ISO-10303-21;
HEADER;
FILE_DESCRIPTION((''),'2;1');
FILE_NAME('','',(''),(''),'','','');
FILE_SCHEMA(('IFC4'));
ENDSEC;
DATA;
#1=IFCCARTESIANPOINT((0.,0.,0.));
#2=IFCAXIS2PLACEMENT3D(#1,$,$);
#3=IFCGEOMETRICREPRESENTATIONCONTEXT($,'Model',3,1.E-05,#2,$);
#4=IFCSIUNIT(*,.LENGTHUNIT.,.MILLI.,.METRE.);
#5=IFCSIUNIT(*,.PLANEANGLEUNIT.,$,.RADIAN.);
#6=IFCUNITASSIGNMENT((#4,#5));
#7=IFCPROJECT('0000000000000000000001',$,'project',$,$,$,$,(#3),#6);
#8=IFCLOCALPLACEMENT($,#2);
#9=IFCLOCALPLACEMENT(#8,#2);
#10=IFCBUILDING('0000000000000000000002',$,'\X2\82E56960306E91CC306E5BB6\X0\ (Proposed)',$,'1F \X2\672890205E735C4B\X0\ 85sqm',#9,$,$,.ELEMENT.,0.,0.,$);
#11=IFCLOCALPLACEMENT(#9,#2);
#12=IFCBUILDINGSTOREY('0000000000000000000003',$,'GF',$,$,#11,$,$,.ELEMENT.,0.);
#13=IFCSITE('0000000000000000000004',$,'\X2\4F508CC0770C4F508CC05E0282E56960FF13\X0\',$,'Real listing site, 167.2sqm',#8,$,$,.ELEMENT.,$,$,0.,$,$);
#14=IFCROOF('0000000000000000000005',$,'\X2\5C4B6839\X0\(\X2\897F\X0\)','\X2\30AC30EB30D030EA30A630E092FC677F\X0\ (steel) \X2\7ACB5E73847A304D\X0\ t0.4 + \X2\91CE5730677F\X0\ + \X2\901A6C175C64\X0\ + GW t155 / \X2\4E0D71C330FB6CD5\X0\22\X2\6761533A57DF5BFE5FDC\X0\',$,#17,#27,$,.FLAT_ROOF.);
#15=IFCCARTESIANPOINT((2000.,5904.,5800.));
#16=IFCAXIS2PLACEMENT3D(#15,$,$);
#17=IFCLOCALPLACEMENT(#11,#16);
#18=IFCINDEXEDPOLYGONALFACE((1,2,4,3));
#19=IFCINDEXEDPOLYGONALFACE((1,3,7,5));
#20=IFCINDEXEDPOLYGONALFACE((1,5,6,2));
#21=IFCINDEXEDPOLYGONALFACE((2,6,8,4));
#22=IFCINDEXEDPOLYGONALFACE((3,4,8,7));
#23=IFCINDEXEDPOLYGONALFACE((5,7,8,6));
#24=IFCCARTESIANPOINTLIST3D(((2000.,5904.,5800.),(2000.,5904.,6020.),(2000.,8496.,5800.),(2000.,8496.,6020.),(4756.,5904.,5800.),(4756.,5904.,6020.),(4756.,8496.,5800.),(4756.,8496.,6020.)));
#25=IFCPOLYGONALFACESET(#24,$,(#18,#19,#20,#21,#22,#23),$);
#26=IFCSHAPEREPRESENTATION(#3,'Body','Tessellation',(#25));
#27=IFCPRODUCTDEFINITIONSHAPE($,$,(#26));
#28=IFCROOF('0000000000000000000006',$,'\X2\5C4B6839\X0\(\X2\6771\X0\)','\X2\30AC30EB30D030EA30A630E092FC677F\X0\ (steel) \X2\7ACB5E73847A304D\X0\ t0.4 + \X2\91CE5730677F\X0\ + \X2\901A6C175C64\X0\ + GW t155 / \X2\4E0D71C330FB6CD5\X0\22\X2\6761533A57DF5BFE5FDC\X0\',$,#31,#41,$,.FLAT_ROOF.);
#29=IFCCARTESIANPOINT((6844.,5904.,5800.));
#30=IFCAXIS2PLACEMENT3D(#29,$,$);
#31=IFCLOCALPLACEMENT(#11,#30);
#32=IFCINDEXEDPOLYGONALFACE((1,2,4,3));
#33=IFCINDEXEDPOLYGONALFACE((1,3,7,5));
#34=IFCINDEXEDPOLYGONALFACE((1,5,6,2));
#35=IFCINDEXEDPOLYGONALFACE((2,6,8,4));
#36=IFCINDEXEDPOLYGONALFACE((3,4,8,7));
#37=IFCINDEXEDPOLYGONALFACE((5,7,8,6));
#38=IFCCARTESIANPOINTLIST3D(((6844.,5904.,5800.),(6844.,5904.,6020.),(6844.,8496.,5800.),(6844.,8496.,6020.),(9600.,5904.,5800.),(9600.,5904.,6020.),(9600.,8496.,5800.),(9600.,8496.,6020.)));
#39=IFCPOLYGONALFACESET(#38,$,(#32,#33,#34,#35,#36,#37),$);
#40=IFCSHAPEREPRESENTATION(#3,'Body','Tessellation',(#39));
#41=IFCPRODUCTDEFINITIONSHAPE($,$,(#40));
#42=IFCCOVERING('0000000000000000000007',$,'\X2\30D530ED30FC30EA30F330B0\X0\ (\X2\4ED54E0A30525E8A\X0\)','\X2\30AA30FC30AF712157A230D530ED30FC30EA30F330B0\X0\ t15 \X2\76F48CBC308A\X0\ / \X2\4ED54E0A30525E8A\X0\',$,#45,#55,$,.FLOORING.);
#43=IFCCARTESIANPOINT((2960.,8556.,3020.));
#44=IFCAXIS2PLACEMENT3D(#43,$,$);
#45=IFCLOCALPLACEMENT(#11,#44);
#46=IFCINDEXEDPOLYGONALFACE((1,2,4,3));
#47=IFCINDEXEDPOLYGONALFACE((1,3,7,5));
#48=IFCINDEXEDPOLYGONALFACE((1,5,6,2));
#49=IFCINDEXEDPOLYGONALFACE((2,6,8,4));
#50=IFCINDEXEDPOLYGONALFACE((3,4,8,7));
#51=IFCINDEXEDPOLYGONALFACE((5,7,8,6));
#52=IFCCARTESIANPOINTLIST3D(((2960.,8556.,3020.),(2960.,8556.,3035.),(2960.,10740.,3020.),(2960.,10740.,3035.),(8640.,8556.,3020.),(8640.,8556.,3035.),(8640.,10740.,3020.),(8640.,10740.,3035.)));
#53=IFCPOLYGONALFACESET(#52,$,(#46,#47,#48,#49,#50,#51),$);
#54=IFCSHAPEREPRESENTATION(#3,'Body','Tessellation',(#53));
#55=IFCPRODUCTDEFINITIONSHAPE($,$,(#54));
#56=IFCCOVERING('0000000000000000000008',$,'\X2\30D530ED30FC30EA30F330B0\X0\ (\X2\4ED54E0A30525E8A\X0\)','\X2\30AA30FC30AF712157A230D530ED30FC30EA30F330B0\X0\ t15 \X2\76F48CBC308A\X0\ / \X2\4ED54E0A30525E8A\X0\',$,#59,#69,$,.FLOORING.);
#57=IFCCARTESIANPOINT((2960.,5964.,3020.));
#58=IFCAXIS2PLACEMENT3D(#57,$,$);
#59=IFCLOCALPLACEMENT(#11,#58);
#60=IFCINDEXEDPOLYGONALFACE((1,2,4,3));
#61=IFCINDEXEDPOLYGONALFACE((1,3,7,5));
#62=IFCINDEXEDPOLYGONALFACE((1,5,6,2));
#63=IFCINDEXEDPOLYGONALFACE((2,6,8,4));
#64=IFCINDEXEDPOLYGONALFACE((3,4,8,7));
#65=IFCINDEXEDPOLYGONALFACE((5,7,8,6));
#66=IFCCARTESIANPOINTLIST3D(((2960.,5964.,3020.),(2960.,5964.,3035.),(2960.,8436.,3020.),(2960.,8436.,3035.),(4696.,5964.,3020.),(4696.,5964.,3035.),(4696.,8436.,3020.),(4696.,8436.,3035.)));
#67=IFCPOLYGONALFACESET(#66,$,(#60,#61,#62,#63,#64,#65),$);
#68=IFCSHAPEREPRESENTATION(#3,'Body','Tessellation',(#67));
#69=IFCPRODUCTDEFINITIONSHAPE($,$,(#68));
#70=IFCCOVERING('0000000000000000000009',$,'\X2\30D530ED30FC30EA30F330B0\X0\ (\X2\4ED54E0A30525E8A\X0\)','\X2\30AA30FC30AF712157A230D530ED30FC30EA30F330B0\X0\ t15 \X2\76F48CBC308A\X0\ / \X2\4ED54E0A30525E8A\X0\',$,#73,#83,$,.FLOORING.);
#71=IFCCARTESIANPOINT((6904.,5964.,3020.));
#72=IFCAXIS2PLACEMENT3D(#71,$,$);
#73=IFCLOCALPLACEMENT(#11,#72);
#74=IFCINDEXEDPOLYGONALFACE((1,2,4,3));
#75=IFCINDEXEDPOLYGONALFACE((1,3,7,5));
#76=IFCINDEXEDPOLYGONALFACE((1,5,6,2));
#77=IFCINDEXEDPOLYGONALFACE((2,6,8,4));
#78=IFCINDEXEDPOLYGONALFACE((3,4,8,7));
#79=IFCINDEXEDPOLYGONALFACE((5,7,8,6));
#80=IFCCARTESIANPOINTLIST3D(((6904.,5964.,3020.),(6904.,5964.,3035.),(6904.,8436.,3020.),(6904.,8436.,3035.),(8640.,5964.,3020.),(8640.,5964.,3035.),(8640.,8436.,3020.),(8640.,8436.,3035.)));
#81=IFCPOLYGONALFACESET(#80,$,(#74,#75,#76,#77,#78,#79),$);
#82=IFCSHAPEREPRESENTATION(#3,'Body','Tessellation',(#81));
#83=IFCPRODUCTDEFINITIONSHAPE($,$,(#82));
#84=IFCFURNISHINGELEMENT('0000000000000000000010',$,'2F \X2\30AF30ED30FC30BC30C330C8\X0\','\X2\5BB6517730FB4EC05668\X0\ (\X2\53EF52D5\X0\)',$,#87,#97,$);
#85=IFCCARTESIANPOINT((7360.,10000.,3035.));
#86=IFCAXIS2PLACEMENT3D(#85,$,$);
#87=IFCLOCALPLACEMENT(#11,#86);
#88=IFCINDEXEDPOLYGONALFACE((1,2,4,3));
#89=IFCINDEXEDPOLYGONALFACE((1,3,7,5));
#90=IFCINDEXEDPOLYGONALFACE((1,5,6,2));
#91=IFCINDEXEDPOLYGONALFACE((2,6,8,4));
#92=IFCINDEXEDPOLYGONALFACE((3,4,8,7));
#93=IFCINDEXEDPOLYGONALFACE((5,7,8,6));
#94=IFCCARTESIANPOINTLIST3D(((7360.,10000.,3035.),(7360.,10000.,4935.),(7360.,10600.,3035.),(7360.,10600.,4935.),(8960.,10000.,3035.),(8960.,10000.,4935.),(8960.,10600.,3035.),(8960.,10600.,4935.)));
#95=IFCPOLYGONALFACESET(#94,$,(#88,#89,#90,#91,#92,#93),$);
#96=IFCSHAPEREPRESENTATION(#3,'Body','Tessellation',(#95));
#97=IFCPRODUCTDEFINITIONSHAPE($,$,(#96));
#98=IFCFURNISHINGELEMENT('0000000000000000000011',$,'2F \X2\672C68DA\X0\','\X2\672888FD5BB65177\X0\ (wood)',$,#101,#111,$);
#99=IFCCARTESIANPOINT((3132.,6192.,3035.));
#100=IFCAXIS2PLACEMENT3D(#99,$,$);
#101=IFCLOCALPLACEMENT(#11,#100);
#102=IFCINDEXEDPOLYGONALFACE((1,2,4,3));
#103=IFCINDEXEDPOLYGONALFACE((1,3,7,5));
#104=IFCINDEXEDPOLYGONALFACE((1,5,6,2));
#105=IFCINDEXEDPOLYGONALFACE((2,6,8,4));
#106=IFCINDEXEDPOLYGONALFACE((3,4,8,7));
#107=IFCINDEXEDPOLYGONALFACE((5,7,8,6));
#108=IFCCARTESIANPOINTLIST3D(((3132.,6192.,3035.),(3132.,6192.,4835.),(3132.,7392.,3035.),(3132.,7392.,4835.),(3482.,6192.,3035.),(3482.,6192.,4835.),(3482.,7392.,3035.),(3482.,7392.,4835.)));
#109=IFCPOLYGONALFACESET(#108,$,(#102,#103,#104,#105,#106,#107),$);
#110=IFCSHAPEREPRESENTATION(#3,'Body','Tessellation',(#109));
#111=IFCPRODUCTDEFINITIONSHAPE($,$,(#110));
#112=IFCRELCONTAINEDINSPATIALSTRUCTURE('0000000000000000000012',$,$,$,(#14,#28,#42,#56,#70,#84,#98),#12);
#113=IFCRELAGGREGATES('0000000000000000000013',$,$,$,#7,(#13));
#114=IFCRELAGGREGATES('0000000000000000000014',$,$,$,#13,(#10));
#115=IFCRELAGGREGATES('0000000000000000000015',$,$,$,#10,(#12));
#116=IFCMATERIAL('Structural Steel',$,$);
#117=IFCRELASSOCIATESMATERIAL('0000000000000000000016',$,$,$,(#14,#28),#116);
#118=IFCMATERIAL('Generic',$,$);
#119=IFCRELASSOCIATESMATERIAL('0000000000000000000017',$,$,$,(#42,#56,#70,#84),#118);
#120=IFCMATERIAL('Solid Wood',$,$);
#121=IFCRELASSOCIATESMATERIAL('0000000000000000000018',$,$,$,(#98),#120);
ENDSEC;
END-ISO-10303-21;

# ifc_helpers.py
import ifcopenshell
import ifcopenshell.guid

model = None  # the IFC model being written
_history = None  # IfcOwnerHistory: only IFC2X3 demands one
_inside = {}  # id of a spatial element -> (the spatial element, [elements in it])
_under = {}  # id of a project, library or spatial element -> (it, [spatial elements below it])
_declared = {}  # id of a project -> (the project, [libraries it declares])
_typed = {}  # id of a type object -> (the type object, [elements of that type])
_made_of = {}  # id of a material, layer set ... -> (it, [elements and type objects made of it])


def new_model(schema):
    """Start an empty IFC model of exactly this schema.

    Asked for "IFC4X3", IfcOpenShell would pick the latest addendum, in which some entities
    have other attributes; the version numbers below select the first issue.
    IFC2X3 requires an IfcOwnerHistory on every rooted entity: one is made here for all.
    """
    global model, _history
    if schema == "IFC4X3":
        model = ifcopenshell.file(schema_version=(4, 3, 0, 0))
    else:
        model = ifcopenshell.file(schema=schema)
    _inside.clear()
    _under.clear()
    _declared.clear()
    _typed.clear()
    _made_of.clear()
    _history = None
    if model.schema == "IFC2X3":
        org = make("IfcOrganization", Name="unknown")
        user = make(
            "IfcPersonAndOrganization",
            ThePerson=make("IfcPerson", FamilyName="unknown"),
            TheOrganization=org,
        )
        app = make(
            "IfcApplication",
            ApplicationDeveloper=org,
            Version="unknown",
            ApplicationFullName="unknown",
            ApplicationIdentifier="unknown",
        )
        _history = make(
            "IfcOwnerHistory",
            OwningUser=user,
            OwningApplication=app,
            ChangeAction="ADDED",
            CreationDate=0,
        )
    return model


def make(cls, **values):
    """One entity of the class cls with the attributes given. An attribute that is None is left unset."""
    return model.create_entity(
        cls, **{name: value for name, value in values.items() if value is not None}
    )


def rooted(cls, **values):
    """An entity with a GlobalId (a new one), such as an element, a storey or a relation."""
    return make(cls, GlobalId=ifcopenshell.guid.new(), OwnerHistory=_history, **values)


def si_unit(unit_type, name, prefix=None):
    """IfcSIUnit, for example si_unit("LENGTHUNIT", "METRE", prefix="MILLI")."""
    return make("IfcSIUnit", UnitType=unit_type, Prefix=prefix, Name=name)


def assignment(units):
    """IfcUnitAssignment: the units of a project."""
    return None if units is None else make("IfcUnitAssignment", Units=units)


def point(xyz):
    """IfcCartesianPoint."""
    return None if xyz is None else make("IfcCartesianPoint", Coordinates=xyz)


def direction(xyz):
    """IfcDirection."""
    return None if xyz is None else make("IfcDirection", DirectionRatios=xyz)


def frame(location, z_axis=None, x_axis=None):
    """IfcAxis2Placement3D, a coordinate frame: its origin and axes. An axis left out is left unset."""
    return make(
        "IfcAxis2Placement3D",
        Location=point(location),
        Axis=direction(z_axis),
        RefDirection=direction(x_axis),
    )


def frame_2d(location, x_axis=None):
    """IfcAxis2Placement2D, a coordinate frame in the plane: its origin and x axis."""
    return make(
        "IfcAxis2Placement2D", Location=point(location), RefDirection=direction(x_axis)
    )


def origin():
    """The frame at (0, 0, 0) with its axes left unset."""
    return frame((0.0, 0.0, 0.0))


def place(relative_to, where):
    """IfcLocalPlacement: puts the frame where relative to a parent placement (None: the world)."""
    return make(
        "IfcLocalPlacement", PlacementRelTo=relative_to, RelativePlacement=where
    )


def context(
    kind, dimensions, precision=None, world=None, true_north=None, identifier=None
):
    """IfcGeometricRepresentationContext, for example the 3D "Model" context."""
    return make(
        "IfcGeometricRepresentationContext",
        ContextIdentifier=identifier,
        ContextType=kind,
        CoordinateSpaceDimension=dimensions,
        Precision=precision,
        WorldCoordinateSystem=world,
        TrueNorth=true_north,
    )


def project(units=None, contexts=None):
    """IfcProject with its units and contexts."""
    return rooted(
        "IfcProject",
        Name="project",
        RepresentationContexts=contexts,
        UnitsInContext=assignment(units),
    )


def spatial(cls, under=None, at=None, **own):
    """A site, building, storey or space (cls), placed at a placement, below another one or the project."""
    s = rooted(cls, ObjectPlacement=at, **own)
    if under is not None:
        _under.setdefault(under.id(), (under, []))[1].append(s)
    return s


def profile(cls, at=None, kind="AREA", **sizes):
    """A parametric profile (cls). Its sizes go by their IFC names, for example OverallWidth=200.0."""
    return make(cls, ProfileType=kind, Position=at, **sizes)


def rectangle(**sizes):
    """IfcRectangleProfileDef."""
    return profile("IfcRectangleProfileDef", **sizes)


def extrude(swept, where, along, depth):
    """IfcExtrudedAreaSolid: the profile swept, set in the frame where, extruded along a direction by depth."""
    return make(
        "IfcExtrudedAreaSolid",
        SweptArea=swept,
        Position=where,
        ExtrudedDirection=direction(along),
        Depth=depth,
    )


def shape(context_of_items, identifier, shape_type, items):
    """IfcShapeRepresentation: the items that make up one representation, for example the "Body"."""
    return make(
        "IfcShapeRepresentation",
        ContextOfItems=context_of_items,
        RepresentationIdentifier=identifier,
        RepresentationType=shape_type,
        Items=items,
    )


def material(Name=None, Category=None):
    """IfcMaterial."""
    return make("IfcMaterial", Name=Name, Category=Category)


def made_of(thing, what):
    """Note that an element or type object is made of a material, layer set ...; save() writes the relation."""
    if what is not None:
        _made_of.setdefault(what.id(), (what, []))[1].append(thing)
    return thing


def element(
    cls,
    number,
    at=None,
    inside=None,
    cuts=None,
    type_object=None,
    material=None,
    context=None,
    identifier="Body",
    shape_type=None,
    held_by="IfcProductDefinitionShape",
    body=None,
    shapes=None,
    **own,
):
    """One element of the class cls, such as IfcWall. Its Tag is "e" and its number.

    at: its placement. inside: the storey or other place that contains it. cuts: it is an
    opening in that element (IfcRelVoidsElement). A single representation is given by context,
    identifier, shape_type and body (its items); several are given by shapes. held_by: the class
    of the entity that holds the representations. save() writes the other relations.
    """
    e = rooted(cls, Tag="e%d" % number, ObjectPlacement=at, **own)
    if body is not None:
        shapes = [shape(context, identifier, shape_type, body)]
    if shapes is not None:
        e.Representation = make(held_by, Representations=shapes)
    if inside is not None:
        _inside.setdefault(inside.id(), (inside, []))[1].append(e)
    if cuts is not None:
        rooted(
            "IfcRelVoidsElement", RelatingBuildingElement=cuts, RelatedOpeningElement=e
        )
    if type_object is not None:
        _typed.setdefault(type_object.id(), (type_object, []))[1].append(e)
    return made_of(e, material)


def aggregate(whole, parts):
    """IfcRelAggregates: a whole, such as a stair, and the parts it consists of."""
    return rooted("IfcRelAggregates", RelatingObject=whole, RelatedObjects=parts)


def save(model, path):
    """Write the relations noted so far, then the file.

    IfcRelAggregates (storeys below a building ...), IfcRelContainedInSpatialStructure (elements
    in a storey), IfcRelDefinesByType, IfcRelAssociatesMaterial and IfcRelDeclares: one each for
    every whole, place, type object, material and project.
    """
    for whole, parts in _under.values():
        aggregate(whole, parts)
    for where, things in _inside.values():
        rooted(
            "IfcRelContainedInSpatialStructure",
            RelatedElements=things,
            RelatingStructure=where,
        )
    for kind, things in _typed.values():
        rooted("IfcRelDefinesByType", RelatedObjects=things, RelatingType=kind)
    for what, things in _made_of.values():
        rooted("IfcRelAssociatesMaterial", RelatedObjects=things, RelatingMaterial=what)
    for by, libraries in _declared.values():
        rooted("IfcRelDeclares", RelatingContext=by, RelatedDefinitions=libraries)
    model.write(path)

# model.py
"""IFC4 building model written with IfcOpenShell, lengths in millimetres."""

from ifc_helpers import new_model, si_unit, frame, frame_2d, origin, place, context, project, spatial, rectangle, extrude, material, element, save


model = new_model("IFC4")

# Units and contexts
model_context = context("Model", 3, precision=1e-05, world=origin())
ifc_project = project(units=[si_unit("LENGTHUNIT", "METRE", prefix="MILLI"), si_unit("PLANEANGLEUNIT", "RADIAN")], contexts=[model_context])

# Site, building, storey
site_placement = place(None, origin())
site = spatial("IfcSite", under=ifc_project, at=site_placement, Name="佐賀県佐賀市若楠３", ObjectType="Real listing site, 167.2sqm", CompositionType="ELEMENT", RefElevation=0.0)
building_placement = place(site_placement, origin())
building = spatial("IfcBuilding", under=site, at=building_placement, Name="若楠の里の家 (Proposed)", ObjectType="1F 木造平屋 85sqm", CompositionType="ELEMENT", ElevationOfRefHeight=0.0, ElevationOfTerrain=0.0)
storey_placement = place(building_placement, origin())
storey = spatial("IfcBuildingStorey", under=building, at=storey_placement, Name="GF", CompositionType="ELEMENT", Elevation=0.0)

# Shared definitions
ifc_material_1 = material(Name="Solid Wood")

# Shared definitions
ifc_material_2 = material(Name="Generic")

# Roofs
ifc_material_3 = material(Name="Structural Steel")
roof_1_placement = place(storey_placement, frame((2000.0, 5904.0, 5800.0)))
element("IfcRoof", 1, at=roof_1_placement, inside=storey, material=ifc_material_3, Name="屋根(西)", Description="ガルバリウム鋼板 (steel) 立平葺き t0.4 + 野地板 + 通気層 + GW t155 / 不燃・法22条区域対応", PredefinedType="FLAT_ROOF", context=model_context, shape_type="SweptSolid", body=[
    extrude(rectangle(XDim=2756.0, YDim=2592.0, at=frame_2d((1378.0, 1296.0))), frame((2000.0, 5904.0, 5800.0)), (0.0, 0.0, 1.0), 220.0),
])
roof_2_placement = place(storey_placement, frame((6844.0, 5904.0, 5800.0)))
element("IfcRoof", 2, at=roof_2_placement, inside=storey, material=ifc_material_3, Name="屋根(東)", Description="ガルバリウム鋼板 (steel) 立平葺き t0.4 + 野地板 + 通気層 + GW t155 / 不燃・法22条区域対応", PredefinedType="FLAT_ROOF", context=model_context, shape_type="SweptSolid", body=[
    extrude(rectangle(XDim=2756.0, YDim=2592.0, at=frame_2d((1378.0, 1296.0))), frame((6844.0, 5904.0, 5800.0)), (0.0, 0.0, 1.0), 220.0),
])

# Coverings
covering_1_placement = place(storey_placement, frame((2960.0, 8556.0, 3020.0)))
element("IfcCovering", 3, at=covering_1_placement, inside=storey, material=ifc_material_2, Name="フローリング (仕上げ床)", Description="オーク無垢フローリング t15 直貼り / 仕上げ床", PredefinedType="FLOORING", context=model_context, shape_type="SweptSolid", body=[
    extrude(rectangle(XDim=5680.0, YDim=2184.0, at=frame_2d((2840.0, 1092.0))), frame((2960.0, 8556.0, 3020.0)), (0.0, 0.0, 1.0), 15.0),
])
covering_2_placement = place(storey_placement, frame((2960.0, 5964.0, 3020.0)))
element("IfcCovering", 4, at=covering_2_placement, inside=storey, material=ifc_material_2, Name="フローリング (仕上げ床)", Description="オーク無垢フローリング t15 直貼り / 仕上げ床", PredefinedType="FLOORING", context=model_context, shape_type="SweptSolid", body=[
    extrude(rectangle(XDim=1736.0, YDim=2472.0, at=frame_2d((868.0, 1236.0))), frame((2960.0, 5964.0, 3020.0)), (0.0, 0.0, 1.0), 15.0),
])
covering_3_placement = place(storey_placement, frame((6904.0, 5964.0, 3020.0)))
element("IfcCovering", 5, at=covering_3_placement, inside=storey, material=ifc_material_2, Name="フローリング (仕上げ床)", Description="オーク無垢フローリング t15 直貼り / 仕上げ床", PredefinedType="FLOORING", context=model_context, shape_type="SweptSolid", body=[
    extrude(rectangle(XDim=1736.0, YDim=2472.0, at=frame_2d((868.0, 1236.0))), frame((6904.0, 5964.0, 3020.0)), (0.0, 0.0, 1.0), 15.0),
])

# Furnishing elements
furnishing_1_placement = place(storey_placement, frame((7360.0, 10000.0, 3035.0)))
element("IfcFurnishingElement", 6, at=furnishing_1_placement, inside=storey, material=ifc_material_2, Name="2F クローゼット", Description="家具・什器 (可動)", context=model_context, shape_type="SweptSolid", body=[
    extrude(rectangle(XDim=1600.0, YDim=600.0, at=frame_2d((800.0, 300.0))), frame((7360.0, 10000.0, 3035.0)), (0.0, 0.0, 1.0), 1900.0),
])
furnishing_2_placement = place(storey_placement, frame((3132.0, 6192.0, 3035.0)))
element("IfcFurnishingElement", 7, at=furnishing_2_placement, inside=storey, material=ifc_material_1, Name="2F 本棚", Description="木製家具 (wood)", context=model_context, shape_type="SweptSolid", body=[
    extrude(rectangle(XDim=350.0, YDim=1200.0, at=frame_2d((175.0, 600.0))), frame((3132.0, 6192.0, 3035.0)), (0.0, 0.0, 1.0), 1800.0),
])

save(model, "model.ifc")
